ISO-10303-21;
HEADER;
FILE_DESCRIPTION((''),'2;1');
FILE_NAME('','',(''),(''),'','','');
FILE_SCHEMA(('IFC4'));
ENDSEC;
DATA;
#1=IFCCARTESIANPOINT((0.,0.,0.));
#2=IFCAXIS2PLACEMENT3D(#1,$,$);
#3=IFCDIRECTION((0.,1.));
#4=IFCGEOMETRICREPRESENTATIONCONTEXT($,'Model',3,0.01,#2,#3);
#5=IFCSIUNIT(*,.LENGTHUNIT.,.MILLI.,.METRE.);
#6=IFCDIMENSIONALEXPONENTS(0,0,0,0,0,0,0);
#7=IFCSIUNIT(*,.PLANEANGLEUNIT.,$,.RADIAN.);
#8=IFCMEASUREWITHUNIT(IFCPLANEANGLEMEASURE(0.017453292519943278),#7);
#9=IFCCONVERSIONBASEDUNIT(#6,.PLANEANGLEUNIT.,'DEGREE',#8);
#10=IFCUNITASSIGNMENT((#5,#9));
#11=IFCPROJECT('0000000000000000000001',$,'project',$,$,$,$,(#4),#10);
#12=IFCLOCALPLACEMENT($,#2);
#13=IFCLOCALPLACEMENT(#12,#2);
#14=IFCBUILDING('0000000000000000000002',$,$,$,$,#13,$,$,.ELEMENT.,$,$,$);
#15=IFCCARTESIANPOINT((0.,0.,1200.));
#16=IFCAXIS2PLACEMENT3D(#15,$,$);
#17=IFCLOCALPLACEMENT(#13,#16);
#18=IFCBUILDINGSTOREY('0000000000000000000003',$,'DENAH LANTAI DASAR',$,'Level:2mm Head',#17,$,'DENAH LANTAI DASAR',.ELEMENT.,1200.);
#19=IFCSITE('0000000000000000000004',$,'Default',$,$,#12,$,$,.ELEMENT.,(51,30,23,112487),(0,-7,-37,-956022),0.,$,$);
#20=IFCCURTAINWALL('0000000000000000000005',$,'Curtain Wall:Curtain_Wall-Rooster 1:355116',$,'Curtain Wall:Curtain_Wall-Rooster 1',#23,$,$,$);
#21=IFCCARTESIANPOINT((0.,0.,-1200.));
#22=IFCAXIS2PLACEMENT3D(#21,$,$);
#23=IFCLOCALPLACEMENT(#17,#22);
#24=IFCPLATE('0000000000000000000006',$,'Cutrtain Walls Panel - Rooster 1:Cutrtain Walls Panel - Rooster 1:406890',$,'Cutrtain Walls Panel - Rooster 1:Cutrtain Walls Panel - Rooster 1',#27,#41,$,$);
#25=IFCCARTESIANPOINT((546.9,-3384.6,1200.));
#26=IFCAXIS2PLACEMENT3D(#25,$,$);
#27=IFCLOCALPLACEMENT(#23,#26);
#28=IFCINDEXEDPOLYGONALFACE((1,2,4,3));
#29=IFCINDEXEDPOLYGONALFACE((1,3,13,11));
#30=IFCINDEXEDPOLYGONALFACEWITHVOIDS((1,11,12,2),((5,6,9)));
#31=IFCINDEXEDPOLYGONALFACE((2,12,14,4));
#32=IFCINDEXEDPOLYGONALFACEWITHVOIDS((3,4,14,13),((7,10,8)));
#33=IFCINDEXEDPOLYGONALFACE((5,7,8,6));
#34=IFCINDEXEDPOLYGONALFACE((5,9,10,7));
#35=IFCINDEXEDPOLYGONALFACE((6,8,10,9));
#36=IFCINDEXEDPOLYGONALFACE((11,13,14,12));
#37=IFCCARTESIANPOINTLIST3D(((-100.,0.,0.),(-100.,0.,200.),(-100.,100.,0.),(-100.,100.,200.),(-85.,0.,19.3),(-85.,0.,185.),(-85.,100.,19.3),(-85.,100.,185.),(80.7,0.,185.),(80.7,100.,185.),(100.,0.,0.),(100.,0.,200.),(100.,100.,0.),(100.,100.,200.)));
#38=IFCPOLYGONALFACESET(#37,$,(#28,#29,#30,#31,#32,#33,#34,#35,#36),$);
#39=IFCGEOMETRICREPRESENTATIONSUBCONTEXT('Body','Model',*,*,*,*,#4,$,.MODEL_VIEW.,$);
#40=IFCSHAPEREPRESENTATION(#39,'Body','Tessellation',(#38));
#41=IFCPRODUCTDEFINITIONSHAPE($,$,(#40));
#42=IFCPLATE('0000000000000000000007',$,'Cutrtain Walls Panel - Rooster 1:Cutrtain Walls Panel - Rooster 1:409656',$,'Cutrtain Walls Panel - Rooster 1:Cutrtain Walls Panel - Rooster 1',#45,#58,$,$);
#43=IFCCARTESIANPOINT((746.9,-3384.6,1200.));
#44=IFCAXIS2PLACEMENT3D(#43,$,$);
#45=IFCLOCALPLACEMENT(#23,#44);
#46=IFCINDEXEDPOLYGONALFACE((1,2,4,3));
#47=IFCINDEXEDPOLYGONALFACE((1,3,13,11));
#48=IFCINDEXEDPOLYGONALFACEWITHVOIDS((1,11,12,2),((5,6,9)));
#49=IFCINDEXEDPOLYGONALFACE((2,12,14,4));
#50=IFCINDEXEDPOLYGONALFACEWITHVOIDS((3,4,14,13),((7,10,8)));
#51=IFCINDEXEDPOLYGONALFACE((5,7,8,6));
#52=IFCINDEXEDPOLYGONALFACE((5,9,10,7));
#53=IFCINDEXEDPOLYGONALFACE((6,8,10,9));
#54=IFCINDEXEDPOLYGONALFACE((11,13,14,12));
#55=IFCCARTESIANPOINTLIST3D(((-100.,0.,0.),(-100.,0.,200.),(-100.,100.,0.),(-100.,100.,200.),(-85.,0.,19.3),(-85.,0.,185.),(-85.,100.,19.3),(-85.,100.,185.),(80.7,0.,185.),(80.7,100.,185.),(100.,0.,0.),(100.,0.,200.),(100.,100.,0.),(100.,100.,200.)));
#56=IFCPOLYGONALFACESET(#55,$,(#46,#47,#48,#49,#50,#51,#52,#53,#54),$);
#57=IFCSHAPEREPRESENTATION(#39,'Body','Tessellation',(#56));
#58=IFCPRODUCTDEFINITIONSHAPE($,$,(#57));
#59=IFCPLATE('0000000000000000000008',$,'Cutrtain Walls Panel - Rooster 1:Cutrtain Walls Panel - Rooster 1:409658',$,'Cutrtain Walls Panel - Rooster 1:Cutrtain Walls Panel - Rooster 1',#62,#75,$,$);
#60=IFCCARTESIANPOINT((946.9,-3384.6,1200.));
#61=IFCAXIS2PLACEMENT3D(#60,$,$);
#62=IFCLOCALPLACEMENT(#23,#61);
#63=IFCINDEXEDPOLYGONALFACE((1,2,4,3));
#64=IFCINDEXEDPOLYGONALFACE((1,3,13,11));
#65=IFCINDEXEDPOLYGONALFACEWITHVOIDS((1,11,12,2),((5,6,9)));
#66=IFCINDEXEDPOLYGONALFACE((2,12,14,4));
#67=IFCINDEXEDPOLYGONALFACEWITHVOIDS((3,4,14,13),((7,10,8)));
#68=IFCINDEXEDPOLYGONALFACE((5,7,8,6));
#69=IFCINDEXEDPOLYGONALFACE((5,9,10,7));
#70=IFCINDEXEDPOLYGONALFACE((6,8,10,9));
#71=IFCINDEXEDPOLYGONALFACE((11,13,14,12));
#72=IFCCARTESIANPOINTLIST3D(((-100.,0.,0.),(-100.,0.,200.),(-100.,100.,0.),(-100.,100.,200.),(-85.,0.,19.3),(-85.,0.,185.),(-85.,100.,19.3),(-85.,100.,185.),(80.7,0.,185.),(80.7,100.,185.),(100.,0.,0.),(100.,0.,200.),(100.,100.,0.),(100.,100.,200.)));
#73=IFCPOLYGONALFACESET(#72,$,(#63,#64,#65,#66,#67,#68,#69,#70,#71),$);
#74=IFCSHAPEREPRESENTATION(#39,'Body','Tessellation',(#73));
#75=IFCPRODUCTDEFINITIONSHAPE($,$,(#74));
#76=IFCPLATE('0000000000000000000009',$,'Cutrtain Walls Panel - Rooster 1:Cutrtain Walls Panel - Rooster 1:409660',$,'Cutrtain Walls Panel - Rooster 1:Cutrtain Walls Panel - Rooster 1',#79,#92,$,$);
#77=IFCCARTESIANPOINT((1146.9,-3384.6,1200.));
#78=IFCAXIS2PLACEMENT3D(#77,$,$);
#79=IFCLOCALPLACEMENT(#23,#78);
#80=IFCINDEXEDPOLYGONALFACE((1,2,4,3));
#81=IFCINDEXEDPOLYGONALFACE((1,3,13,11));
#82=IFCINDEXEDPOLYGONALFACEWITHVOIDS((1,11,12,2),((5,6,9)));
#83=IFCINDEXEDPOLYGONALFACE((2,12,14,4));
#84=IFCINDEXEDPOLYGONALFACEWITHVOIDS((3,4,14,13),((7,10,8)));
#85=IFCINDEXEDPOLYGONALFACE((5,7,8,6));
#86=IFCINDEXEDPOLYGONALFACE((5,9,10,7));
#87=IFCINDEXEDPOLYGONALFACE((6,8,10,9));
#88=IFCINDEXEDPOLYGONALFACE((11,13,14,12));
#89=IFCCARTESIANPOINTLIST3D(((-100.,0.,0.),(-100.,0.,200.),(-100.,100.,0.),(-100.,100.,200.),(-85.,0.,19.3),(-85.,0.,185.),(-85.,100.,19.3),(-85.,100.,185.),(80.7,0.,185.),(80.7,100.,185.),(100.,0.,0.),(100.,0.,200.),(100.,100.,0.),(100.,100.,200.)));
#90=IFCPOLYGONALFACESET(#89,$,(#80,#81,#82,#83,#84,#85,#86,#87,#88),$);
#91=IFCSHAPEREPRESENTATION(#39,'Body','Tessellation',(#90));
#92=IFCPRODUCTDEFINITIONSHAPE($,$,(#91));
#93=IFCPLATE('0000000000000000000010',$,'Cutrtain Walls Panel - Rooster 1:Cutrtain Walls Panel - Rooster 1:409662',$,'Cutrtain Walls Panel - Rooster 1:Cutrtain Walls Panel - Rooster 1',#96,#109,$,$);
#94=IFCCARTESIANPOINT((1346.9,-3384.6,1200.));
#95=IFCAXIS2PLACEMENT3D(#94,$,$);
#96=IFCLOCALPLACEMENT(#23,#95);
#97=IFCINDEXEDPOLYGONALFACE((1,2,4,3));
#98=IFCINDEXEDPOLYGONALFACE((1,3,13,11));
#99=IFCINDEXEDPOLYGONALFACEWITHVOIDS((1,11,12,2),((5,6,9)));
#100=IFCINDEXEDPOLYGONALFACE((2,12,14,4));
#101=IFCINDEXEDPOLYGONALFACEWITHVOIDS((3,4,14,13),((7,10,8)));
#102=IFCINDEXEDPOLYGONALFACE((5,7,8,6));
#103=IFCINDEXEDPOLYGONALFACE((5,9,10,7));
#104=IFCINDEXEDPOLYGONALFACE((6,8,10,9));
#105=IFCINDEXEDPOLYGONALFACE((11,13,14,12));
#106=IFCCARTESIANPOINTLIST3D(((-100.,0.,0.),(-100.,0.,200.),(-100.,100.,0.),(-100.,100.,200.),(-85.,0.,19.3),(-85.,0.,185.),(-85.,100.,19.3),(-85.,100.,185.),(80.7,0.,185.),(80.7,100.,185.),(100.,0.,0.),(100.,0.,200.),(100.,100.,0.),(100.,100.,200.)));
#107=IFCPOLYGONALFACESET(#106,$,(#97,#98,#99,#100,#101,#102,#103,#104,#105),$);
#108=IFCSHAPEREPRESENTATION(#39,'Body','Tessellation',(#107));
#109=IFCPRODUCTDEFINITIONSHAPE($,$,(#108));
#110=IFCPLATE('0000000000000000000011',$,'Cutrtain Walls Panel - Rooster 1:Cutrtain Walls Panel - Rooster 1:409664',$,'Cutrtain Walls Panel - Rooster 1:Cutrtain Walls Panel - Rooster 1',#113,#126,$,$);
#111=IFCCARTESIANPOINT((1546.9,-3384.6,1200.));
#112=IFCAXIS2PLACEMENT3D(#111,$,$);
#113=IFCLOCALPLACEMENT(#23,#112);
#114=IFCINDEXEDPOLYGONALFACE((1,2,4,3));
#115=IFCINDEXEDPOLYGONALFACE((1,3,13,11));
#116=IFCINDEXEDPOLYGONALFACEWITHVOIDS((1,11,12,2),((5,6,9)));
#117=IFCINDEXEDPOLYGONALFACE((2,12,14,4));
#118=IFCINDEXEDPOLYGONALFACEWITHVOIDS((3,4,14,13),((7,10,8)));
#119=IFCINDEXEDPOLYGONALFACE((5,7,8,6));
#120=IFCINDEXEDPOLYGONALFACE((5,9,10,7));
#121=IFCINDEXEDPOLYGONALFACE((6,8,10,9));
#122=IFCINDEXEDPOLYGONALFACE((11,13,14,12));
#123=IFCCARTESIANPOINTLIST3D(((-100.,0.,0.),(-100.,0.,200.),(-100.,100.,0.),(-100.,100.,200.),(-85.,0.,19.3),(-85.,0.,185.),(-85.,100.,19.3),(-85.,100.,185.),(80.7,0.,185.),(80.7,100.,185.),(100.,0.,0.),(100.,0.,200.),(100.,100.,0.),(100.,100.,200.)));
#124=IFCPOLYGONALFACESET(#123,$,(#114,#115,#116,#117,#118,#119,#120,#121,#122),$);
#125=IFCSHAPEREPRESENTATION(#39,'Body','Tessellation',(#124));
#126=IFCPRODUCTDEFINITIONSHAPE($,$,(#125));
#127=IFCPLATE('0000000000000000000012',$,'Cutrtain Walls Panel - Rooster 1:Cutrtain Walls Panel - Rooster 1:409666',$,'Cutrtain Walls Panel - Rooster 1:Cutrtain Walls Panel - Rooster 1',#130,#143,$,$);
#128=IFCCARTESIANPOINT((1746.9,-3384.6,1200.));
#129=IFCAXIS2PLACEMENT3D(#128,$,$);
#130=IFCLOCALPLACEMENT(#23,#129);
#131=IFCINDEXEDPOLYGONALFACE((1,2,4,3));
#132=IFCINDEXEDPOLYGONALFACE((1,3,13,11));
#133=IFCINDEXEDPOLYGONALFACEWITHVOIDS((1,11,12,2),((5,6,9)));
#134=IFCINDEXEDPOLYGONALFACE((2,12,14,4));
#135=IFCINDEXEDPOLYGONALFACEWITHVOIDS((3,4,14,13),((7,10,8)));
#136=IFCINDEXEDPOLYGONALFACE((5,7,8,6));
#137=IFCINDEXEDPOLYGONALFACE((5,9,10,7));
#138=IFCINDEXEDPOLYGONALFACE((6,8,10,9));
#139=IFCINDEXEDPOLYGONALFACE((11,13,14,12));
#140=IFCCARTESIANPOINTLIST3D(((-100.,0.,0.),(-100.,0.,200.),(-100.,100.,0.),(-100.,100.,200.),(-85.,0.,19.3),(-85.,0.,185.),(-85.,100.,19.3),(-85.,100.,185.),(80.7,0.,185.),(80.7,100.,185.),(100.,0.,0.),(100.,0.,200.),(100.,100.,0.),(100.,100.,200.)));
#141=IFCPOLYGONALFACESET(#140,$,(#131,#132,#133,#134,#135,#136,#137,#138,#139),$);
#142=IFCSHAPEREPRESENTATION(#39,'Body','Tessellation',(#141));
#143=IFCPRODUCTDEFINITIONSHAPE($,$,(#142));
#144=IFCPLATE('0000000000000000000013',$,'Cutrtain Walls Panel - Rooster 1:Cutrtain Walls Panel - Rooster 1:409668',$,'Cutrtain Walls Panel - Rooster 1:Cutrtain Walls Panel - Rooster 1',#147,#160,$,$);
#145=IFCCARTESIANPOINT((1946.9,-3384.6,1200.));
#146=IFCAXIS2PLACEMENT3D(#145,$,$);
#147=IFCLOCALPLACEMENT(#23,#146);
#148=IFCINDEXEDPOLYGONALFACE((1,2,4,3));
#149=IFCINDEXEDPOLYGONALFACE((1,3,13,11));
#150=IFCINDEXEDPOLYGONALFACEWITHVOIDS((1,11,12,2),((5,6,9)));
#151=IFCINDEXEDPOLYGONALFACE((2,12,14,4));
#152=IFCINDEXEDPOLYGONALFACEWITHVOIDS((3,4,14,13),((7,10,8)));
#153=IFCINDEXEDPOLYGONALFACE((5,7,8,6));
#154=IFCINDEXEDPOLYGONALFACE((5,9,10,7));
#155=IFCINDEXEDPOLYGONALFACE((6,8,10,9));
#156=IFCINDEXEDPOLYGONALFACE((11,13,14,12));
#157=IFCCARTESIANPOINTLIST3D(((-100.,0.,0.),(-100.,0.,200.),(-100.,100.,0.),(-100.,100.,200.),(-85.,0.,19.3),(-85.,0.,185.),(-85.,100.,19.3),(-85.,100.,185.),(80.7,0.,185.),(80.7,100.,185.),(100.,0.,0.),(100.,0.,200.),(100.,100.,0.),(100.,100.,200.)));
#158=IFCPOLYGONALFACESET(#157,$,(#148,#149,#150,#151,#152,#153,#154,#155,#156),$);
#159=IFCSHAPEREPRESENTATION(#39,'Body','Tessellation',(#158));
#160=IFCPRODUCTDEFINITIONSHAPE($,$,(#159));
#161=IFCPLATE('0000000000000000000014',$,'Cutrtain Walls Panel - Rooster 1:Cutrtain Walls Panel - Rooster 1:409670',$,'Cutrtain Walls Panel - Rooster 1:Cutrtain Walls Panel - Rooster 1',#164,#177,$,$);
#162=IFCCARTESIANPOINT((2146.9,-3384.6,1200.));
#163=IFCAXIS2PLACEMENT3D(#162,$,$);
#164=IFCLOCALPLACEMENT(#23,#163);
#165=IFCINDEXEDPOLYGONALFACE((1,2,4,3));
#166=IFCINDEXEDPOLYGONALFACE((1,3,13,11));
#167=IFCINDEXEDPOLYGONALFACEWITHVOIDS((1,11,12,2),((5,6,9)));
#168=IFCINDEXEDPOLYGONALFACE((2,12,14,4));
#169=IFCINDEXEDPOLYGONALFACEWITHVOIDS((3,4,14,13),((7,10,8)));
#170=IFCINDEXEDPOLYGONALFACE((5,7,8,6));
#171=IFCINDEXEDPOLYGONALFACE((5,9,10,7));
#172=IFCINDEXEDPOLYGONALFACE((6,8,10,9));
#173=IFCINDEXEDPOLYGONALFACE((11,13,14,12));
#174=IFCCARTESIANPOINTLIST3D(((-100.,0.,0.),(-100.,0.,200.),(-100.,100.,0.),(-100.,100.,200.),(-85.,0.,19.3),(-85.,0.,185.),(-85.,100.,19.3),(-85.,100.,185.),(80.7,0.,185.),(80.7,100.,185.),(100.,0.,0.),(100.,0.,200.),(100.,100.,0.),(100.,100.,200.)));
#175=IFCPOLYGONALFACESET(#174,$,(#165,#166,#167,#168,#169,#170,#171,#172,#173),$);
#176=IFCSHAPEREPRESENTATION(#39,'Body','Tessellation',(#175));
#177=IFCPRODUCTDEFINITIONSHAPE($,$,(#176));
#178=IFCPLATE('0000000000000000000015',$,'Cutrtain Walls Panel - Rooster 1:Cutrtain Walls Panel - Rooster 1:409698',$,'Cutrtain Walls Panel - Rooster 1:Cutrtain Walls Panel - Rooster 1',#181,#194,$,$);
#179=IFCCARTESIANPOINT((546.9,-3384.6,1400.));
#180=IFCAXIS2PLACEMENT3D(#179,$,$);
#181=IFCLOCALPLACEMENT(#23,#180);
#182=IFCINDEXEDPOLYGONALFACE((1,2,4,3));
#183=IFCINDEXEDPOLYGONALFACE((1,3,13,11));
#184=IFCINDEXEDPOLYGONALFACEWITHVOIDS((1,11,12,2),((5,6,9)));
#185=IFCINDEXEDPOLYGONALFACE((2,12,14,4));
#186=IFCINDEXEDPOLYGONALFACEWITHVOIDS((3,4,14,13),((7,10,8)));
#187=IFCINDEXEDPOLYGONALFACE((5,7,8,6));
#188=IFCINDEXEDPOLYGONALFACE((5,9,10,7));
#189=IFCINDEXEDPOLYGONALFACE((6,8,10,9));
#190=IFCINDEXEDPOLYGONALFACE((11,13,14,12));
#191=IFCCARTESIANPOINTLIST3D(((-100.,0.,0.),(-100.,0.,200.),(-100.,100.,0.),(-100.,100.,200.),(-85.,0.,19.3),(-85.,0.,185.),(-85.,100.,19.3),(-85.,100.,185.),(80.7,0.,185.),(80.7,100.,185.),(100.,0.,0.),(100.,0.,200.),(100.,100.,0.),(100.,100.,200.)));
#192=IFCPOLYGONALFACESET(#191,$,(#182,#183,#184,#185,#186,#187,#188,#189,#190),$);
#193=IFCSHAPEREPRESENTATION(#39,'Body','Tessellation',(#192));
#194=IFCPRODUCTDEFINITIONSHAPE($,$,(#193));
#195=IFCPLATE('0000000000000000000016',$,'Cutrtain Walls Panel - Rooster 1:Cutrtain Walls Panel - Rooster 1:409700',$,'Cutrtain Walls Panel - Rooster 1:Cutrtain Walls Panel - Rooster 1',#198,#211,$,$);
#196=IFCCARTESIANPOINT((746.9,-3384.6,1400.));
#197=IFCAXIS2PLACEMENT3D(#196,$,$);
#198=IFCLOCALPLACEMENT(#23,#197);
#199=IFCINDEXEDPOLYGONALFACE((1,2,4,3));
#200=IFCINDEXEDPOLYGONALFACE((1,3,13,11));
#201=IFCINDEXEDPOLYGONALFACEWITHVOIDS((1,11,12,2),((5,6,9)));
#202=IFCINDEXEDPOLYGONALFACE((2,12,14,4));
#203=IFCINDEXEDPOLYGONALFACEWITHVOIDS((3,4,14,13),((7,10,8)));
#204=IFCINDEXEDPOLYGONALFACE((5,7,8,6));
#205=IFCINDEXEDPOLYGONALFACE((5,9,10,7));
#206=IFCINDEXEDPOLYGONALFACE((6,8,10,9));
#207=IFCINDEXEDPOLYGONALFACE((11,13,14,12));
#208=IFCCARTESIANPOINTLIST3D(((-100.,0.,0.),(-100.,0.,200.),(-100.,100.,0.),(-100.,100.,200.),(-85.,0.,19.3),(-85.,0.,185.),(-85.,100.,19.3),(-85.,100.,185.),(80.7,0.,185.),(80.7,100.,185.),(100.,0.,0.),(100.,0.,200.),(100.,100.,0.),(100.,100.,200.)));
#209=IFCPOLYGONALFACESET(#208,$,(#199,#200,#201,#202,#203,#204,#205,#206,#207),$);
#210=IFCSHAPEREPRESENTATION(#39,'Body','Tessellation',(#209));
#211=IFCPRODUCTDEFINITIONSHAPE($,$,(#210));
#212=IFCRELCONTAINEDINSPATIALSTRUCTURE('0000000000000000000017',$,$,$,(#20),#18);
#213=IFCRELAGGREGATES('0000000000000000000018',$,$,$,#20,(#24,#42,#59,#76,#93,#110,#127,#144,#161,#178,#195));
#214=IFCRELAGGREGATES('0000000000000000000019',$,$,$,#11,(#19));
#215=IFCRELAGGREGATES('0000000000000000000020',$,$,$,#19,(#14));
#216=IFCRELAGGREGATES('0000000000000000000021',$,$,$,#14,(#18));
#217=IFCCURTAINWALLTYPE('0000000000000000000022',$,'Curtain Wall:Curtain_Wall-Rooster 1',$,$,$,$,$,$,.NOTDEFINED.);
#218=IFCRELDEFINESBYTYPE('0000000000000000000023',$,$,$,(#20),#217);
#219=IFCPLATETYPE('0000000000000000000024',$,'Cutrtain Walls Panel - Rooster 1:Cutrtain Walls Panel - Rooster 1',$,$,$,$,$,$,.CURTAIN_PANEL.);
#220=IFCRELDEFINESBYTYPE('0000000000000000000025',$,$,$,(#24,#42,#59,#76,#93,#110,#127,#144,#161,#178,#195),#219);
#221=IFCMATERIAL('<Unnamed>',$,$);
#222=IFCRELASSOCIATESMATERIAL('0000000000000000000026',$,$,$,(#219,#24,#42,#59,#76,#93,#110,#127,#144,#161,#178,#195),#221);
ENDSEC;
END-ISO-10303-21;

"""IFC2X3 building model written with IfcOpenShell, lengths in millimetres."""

from ifc_helpers import new_model, entity, si_unit, converted_unit, direction, frame, origin, place, context, subcontext, project, spatial, polyline, outline, extrude, source, transform, mapped, material, type_object, type_shapes, element, aggregate, save


model = new_model("IFC2X3")

# Units and contexts
model_context = context("Model", 3, precision=0.01, world=origin(), true_north=direction((0.0, 1.0)))
body_context = subcontext(model_context, "Body", "Model", "MODEL_VIEW")
ifc_project = project(units=[si_unit("LENGTHUNIT", "METRE", prefix="MILLI"), converted_unit("PLANEANGLEUNIT", "DEGREE", entity("IfcPlaneAngleMeasure", 0.017453292519943278), si_unit("PLANEANGLEUNIT", "RADIAN"), dimensions=[0, 0, 0, 0, 0, 0, 0])], contexts=[model_context])

# Site, building, storey
site_placement = place(None, origin())
site = spatial("IfcSite", under=ifc_project, at=site_placement, Name="Default", CompositionType="ELEMENT", RefLatitude=(51, 30, 23, 112487), RefLongitude=(0, -7, -37, -956022), RefElevation=0.0)
building_placement = place(site_placement, origin())
building = spatial("IfcBuilding", under=site, at=building_placement, CompositionType="ELEMENT")
storey_placement = place(building_placement, frame((0.0, 0.0, 1200.0)))
storey = spatial("IfcBuildingStorey", under=building, at=storey_placement, Name="DENAH LANTAI DASAR", ObjectType="Level:2mm Head", LongName="DENAH LANTAI DASAR", CompositionType="ELEMENT", Elevation=1200.0)

# Curtain wall, plates
curtain_wall_type = type_object("IfcCurtainWallType", Name="Curtain Wall:Curtain_Wall-Rooster 1", PredefinedType="NOTDEFINED")
curtain_wall_1_placement = place(storey_placement, frame((0.0, 0.0, -1200.0)))
curtain_wall_1 = element("IfcCurtainWall", 1, at=curtain_wall_1_placement, inside=storey, type_object=curtain_wall_type, Name="Curtain Wall:Curtain_Wall-Rooster 1:355116", ObjectType="Curtain Wall:Curtain_Wall-Rooster 1")
ifc_material_1 = material(Name="<Unnamed>")
plate_type = type_object("IfcPlateType", Name="Cutrtain Walls Panel - Rooster 1:Cutrtain Walls Panel - Rooster 1", PredefinedType="CURTAIN_PANEL", material=ifc_material_1)
shared_shape = source(origin(), body_context, "Body", "SweptSolid", [
    extrude(outline(polyline([(-100.0, -100.0), (100.0, -100.0), (100.0, 100.0), (-100.0, 100.0), (-100.0, -100.0)]), holes=[polyline([(80.7, 85.0), (-85.0, -80.7), (-85.0, 85.0), (80.7, 85.0)])]), frame((0.0, 0.0, 100.0), z_axis=(0.0, 1.0, 0.0), x_axis=(0.0, 0.0, -1.0)), (0.0, 0.0, 1.0), 100.0),
])
type_shapes(plate_type, [shared_shape])
plate_1_placement = place(curtain_wall_1_placement, frame((546.9, -3384.6, 1200.0)))
plate_1 = element("IfcPlate", 2, at=plate_1_placement, type_object=plate_type, material=ifc_material_1, Name="Cutrtain Walls Panel - Rooster 1:Cutrtain Walls Panel - Rooster 1:406890", ObjectType="Cutrtain Walls Panel - Rooster 1:Cutrtain Walls Panel - Rooster 1", context=body_context, shape_type="MappedRepresentation", body=[
    mapped(shared_shape, transform((0.0, 0.0, 0.0), scale=1.0)),
])
plate_2_placement = place(curtain_wall_1_placement, frame((746.9, -3384.6, 1200.0)))
plate_2 = element("IfcPlate", 3, at=plate_2_placement, type_object=plate_type, material=ifc_material_1, Name="Cutrtain Walls Panel - Rooster 1:Cutrtain Walls Panel - Rooster 1:409656", ObjectType="Cutrtain Walls Panel - Rooster 1:Cutrtain Walls Panel - Rooster 1", context=body_context, shape_type="MappedRepresentation", body=[
    mapped(shared_shape, transform((0.0, 0.0, 0.0), scale=1.0)),
])
plate_3_placement = place(curtain_wall_1_placement, frame((946.9, -3384.6, 1200.0)))
plate_3 = element("IfcPlate", 4, at=plate_3_placement, type_object=plate_type, material=ifc_material_1, Name="Cutrtain Walls Panel - Rooster 1:Cutrtain Walls Panel - Rooster 1:409658", ObjectType="Cutrtain Walls Panel - Rooster 1:Cutrtain Walls Panel - Rooster 1", context=body_context, shape_type="MappedRepresentation", body=[
    mapped(shared_shape, transform((0.0, 0.0, 0.0), scale=1.0)),
])
plate_4_placement = place(curtain_wall_1_placement, frame((1146.9, -3384.6, 1200.0)))
plate_4 = element("IfcPlate", 5, at=plate_4_placement, type_object=plate_type, material=ifc_material_1, Name="Cutrtain Walls Panel - Rooster 1:Cutrtain Walls Panel - Rooster 1:409660", ObjectType="Cutrtain Walls Panel - Rooster 1:Cutrtain Walls Panel - Rooster 1", context=body_context, shape_type="MappedRepresentation", body=[
    mapped(shared_shape, transform((0.0, 0.0, 0.0), scale=1.0)),
])
plate_5_placement = place(curtain_wall_1_placement, frame((1346.9, -3384.6, 1200.0)))
plate_5 = element("IfcPlate", 6, at=plate_5_placement, type_object=plate_type, material=ifc_material_1, Name="Cutrtain Walls Panel - Rooster 1:Cutrtain Walls Panel - Rooster 1:409662", ObjectType="Cutrtain Walls Panel - Rooster 1:Cutrtain Walls Panel - Rooster 1", context=body_context, shape_type="MappedRepresentation", body=[
    mapped(shared_shape, transform((0.0, 0.0, 0.0), scale=1.0)),
])
plate_6_placement = place(curtain_wall_1_placement, frame((1546.9, -3384.6, 1200.0)))
plate_6 = element("IfcPlate", 7, at=plate_6_placement, type_object=plate_type, material=ifc_material_1, Name="Cutrtain Walls Panel - Rooster 1:Cutrtain Walls Panel - Rooster 1:409664", ObjectType="Cutrtain Walls Panel - Rooster 1:Cutrtain Walls Panel - Rooster 1", context=body_context, shape_type="MappedRepresentation", body=[
    mapped(shared_shape, transform((0.0, 0.0, 0.0), scale=1.0)),
])
plate_7_placement = place(curtain_wall_1_placement, frame((1746.9, -3384.6, 1200.0)))
plate_7 = element("IfcPlate", 8, at=plate_7_placement, type_object=plate_type, material=ifc_material_1, Name="Cutrtain Walls Panel - Rooster 1:Cutrtain Walls Panel - Rooster 1:409666", ObjectType="Cutrtain Walls Panel - Rooster 1:Cutrtain Walls Panel - Rooster 1", context=body_context, shape_type="MappedRepresentation", body=[
    mapped(shared_shape, transform((0.0, 0.0, 0.0), scale=1.0)),
])
plate_8_placement = place(curtain_wall_1_placement, frame((1946.9, -3384.6, 1200.0)))
plate_8 = element("IfcPlate", 9, at=plate_8_placement, type_object=plate_type, material=ifc_material_1, Name="Cutrtain Walls Panel - Rooster 1:Cutrtain Walls Panel - Rooster 1:409668", ObjectType="Cutrtain Walls Panel - Rooster 1:Cutrtain Walls Panel - Rooster 1", context=body_context, shape_type="MappedRepresentation", body=[
    mapped(shared_shape, transform((0.0, 0.0, 0.0), scale=1.0)),
])
plate_9_placement = place(curtain_wall_1_placement, frame((2146.9, -3384.6, 1200.0)))
plate_9 = element("IfcPlate", 10, at=plate_9_placement, type_object=plate_type, material=ifc_material_1, Name="Cutrtain Walls Panel - Rooster 1:Cutrtain Walls Panel - Rooster 1:409670", ObjectType="Cutrtain Walls Panel - Rooster 1:Cutrtain Walls Panel - Rooster 1", context=body_context, shape_type="MappedRepresentation", body=[
    mapped(shared_shape, transform((0.0, 0.0, 0.0), scale=1.0)),
])
plate_10_placement = place(curtain_wall_1_placement, frame((546.9, -3384.6, 1400.0)))
plate_10 = element("IfcPlate", 11, at=plate_10_placement, type_object=plate_type, material=ifc_material_1, Name="Cutrtain Walls Panel - Rooster 1:Cutrtain Walls Panel - Rooster 1:409698", ObjectType="Cutrtain Walls Panel - Rooster 1:Cutrtain Walls Panel - Rooster 1", context=body_context, shape_type="MappedRepresentation", body=[
    mapped(shared_shape, transform((0.0, 0.0, 0.0), scale=1.0)),
])
plate_11_placement = place(curtain_wall_1_placement, frame((746.9, -3384.6, 1400.0)))
plate_11 = element("IfcPlate", 12, at=plate_11_placement, type_object=plate_type, material=ifc_material_1, Name="Cutrtain Walls Panel - Rooster 1:Cutrtain Walls Panel - Rooster 1:409700", ObjectType="Cutrtain Walls Panel - Rooster 1:Cutrtain Walls Panel - Rooster 1", context=body_context, shape_type="MappedRepresentation", body=[
    mapped(shared_shape, transform((0.0, 0.0, 0.0), scale=1.0)),
])
aggregate(curtain_wall_1, [plate_1, plate_2, plate_3, plate_4, plate_5, plate_6, plate_7, plate_8, plate_9, plate_10, plate_11])

save(model, "model.ifc")
